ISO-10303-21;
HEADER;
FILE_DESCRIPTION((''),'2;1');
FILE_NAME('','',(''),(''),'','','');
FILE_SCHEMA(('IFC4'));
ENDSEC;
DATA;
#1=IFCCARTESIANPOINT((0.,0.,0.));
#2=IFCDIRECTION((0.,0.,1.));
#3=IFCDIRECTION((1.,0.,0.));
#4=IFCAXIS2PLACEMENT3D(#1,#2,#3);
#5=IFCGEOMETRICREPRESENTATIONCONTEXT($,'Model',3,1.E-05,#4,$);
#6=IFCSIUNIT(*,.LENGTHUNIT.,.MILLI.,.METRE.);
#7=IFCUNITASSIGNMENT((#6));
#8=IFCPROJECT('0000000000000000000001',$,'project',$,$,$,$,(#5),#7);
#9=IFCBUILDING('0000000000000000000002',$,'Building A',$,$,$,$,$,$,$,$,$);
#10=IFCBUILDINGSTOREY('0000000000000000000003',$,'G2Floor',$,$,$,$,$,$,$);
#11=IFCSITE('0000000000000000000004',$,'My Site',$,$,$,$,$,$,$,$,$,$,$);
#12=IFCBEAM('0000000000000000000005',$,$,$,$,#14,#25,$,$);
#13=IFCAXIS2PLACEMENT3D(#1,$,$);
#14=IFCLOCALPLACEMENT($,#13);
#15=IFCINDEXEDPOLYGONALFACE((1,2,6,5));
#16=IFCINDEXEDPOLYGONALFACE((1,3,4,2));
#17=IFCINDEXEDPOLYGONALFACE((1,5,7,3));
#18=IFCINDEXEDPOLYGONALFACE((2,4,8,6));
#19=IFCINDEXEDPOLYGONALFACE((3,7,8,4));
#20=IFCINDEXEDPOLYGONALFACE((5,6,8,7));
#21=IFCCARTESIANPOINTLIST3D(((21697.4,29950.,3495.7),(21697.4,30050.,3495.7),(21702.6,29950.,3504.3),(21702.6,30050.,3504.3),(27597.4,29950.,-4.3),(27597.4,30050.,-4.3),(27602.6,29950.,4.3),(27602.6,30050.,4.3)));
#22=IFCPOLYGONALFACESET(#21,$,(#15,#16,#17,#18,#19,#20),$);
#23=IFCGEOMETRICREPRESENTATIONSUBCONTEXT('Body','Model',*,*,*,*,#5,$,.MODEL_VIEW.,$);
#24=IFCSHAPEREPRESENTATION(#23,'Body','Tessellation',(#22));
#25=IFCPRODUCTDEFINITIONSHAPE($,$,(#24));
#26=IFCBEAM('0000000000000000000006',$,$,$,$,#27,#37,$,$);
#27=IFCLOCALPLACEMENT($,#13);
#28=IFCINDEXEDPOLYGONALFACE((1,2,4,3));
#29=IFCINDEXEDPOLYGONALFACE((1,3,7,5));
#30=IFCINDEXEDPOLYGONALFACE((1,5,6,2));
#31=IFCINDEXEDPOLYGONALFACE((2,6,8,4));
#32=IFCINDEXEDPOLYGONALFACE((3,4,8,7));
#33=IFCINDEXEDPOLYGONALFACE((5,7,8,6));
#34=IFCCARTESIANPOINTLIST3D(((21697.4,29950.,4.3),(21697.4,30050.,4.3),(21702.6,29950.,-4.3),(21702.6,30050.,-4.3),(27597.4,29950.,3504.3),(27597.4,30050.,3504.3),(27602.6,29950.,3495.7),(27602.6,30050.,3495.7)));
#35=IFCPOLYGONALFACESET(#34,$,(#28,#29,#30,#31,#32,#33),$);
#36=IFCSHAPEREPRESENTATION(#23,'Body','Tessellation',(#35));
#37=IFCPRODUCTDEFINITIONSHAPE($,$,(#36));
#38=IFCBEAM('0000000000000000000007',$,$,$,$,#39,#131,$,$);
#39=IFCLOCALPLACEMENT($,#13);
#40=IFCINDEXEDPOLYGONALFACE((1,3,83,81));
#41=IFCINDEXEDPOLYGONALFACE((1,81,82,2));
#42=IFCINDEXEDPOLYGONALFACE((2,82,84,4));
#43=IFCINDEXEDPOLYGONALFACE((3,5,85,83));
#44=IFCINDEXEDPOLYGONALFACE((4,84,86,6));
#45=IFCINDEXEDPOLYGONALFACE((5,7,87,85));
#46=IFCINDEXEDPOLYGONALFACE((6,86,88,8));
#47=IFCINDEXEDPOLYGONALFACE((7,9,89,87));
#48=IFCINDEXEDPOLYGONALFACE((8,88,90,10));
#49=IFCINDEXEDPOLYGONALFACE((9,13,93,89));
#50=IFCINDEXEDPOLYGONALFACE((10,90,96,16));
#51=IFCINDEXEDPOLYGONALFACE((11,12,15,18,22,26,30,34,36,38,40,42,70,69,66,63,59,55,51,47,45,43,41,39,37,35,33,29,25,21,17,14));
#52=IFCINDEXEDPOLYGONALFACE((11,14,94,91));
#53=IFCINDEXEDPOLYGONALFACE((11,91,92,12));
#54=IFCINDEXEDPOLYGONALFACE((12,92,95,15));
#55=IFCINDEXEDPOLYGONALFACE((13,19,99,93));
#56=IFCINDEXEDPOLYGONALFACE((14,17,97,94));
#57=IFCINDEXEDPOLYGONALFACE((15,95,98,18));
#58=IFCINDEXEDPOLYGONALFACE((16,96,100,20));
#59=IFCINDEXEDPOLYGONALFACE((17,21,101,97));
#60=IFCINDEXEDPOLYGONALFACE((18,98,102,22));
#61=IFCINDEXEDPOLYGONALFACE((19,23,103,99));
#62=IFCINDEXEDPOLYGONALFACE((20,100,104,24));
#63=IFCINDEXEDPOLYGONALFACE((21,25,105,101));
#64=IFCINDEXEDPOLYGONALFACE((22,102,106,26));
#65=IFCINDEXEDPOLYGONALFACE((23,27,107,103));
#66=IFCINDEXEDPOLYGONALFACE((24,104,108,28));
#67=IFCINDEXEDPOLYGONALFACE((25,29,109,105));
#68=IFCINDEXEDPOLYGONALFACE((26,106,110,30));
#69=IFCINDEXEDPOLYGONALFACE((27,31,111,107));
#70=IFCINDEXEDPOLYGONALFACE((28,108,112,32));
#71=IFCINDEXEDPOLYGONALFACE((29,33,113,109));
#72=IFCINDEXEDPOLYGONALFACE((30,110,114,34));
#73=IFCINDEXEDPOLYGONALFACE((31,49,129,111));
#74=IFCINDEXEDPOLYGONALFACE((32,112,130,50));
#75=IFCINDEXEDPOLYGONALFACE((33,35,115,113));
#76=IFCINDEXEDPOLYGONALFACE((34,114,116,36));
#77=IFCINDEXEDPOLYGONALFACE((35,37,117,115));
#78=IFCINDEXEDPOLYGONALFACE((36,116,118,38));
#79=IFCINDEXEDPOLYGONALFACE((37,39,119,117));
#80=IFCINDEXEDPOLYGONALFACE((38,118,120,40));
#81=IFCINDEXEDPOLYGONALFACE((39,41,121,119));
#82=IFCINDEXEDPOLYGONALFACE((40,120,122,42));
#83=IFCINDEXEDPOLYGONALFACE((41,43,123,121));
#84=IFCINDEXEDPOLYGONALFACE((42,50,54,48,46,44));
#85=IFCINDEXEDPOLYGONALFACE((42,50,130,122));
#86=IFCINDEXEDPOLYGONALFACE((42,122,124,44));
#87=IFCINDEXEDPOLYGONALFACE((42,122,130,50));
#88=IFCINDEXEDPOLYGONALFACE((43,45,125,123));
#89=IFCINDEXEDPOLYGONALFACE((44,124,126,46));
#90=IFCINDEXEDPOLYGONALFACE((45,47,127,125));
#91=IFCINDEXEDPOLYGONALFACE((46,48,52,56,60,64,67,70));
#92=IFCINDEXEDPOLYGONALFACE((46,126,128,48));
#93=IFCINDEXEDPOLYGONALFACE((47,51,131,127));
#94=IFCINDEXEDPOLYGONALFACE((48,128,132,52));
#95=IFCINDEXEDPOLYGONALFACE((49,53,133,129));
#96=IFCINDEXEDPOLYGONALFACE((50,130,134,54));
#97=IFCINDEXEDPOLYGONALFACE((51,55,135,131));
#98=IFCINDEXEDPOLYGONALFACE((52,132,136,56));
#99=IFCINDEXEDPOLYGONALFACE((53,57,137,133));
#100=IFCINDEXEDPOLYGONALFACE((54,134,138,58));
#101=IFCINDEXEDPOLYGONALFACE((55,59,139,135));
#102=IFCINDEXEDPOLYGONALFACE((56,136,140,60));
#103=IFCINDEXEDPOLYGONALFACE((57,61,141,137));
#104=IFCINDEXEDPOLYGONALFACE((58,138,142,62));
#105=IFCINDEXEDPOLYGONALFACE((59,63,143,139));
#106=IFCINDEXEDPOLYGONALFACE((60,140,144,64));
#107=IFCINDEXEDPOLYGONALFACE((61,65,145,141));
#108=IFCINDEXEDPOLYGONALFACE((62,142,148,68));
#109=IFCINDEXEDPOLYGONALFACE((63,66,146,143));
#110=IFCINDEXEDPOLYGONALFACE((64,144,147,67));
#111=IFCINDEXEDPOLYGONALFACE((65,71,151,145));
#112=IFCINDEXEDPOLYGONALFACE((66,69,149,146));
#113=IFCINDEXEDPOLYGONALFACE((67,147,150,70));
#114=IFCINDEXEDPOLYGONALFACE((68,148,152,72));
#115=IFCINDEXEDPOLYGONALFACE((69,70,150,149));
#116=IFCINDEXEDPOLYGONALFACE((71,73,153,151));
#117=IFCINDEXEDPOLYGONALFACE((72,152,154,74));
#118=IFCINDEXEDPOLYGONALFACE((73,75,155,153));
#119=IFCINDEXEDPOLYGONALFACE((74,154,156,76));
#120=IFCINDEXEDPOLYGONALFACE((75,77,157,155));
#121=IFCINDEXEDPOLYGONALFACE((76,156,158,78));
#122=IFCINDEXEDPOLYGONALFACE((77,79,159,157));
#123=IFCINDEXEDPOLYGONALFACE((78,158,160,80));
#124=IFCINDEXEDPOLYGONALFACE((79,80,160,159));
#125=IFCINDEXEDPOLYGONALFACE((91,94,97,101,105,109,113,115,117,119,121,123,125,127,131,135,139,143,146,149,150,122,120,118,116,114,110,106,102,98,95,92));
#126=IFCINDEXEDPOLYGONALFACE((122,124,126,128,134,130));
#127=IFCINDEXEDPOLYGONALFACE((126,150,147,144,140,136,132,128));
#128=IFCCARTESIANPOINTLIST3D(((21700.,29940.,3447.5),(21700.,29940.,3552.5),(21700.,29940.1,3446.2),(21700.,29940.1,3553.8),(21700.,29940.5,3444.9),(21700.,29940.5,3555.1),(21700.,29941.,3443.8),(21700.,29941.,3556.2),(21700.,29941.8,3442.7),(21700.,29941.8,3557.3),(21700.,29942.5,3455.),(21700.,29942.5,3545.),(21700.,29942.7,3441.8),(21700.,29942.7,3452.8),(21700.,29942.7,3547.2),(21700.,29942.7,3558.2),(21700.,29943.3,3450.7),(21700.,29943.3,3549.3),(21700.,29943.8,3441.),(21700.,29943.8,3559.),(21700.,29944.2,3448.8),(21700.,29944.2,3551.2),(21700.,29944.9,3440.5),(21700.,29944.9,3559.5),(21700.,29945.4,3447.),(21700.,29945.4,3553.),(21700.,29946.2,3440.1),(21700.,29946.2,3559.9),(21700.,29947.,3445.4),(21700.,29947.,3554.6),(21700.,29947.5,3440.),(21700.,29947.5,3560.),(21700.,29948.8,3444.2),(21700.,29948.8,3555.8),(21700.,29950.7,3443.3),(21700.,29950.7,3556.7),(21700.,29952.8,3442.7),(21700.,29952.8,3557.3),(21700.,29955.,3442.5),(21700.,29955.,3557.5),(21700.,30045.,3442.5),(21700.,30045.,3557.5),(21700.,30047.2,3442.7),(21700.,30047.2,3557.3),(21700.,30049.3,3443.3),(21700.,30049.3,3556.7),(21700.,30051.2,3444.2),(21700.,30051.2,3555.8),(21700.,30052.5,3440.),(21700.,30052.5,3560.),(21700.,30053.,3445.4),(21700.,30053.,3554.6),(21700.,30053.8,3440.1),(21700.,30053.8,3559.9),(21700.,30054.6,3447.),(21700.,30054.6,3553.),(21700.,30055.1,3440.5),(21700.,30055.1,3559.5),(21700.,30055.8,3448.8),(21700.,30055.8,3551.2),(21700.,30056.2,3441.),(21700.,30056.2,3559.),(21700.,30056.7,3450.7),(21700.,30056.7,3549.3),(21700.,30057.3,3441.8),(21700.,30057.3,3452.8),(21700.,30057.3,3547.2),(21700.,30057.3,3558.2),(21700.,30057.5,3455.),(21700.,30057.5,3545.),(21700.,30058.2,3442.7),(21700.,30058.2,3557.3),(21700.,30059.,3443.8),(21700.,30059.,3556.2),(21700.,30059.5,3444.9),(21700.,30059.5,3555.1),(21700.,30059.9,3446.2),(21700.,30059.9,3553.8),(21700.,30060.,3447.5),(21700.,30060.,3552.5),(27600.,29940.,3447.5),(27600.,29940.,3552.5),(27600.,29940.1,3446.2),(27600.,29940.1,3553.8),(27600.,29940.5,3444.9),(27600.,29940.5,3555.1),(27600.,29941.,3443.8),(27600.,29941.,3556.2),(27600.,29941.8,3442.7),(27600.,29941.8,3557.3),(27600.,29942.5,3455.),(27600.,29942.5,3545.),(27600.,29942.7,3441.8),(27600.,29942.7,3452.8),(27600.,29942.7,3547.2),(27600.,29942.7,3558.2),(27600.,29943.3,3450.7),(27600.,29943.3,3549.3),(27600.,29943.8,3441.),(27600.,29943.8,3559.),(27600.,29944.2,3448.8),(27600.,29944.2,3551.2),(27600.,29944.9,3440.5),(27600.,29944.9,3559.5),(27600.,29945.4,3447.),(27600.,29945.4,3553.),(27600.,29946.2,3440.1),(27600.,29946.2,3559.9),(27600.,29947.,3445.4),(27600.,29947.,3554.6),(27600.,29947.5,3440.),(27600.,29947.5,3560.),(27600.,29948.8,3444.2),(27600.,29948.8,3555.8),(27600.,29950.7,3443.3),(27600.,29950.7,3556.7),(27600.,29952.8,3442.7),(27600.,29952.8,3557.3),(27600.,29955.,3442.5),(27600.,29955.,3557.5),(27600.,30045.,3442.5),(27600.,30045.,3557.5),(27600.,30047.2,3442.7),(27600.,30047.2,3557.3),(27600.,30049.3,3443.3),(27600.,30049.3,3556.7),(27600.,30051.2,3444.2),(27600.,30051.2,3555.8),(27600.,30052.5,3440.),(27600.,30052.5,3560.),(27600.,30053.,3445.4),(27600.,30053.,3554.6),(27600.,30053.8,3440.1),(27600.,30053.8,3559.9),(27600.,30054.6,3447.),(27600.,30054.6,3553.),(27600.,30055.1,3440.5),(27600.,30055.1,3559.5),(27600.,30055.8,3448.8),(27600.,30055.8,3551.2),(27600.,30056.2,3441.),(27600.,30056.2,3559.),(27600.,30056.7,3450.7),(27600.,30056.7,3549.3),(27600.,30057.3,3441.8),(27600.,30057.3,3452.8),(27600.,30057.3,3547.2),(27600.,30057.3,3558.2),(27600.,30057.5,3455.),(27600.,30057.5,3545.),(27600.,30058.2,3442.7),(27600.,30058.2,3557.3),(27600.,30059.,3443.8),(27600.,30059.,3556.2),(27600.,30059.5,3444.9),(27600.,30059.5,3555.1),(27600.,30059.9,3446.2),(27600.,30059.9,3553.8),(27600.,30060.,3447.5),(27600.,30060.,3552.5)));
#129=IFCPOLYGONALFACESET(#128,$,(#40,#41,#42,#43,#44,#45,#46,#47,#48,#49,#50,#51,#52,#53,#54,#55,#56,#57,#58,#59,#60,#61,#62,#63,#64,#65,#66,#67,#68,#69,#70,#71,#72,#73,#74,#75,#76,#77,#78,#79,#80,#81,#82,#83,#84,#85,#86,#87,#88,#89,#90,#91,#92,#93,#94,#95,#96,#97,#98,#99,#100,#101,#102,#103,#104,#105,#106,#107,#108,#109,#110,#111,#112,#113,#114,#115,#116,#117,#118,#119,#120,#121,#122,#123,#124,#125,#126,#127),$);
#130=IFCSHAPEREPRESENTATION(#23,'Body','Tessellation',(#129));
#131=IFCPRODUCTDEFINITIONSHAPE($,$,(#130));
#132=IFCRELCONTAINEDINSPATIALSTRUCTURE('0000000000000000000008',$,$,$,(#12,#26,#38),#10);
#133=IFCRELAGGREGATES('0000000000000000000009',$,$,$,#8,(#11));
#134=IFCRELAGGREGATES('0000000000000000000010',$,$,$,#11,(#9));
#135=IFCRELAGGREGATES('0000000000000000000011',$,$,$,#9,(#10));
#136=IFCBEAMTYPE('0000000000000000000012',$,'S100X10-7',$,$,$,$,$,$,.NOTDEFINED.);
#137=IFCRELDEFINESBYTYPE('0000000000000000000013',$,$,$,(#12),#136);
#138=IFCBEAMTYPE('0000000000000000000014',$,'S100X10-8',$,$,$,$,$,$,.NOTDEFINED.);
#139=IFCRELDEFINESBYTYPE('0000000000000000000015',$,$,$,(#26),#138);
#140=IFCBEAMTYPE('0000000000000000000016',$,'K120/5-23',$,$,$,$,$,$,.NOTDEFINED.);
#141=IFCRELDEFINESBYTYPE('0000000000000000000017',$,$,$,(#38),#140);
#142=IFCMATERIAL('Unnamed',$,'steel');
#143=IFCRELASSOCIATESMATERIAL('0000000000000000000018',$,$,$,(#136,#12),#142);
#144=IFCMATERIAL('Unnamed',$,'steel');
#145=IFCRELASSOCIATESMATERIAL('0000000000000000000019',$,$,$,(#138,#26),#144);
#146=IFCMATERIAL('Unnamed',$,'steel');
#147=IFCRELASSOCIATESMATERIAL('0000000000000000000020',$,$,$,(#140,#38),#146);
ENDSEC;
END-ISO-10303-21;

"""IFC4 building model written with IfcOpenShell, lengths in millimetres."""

from ifc_helpers import new_model, si_unit, frame, origin_with_axes, place, context, subcontext, project, spatial, polyline, outline, extrude, material, material_profile, profile_set, profile_usage, type_object, element, save


model = new_model("IFC4")

# Units and contexts
model_context = context("Model", 3, precision=1e-05, world=origin_with_axes())
body_context = subcontext(model_context, "Body", "Model", "MODEL_VIEW")
ifc_project = project(units=[si_unit("LENGTHUNIT", "METRE", prefix="MILLI")], contexts=[model_context])

# Site, building, storey
site = spatial("IfcSite", under=ifc_project, Name="My Site")
building = spatial("IfcBuilding", under=site, Name="Building A")
storey = spatial("IfcBuildingStorey", under=building, Name="G2Floor")

# Beams
ifc_material_1 = material(Name="Unnamed", Category="steel")
ifc_material_profile_1 = material_profile(ifc_material_1, outline(polyline([(50.0, -5.0), (50.0, 5.0), (50.0, 5.0), (-50.0, 5.0), (-50.0, 5.0), (-50.0, -5.0), (-50.0, -5.0), (50.0, -5.0)])))
ifc_profile_set_1 = profile_set([ifc_material_profile_1], Name="S100X10-7")
ifc_profile_usage_1 = profile_usage(ifc_profile_set_1)
beam_type_1 = type_object("IfcBeamType", Name="S100X10-7", PredefinedType="NOTDEFINED", material=ifc_profile_set_1)
beam_1_placement = place(None, frame((21700.0, 30000.0, 3500.0), z_axis=(0.860055, 0.0, -0.510202), x_axis=(0.0, -1.0, 0.0)))
element("IfcBeam", 1, at=beam_1_placement, inside=storey, type_object=beam_type_1, material=ifc_profile_usage_1, context=body_context, shape_type="SweptSolid", body=[
    extrude(outline(polyline([(50.0, -5.0), (50.0, 5.0), (50.0, 5.0), (-50.0, 5.0), (-50.0, 5.0), (-50.0, -5.0), (-50.0, -5.0), (50.0, -5.0)])), origin_with_axes(), (0.0, 0.0, 1.0), 6860.0),
])
ifc_material_2 = material(Name="Unnamed", Category="steel")
ifc_material_profile_2 = material_profile(ifc_material_2, outline(polyline([(50.0, -5.0), (50.0, 5.0), (50.0, 5.0), (-50.0, 5.0), (-50.0, 5.0), (-50.0, -5.0), (-50.0, -5.0), (50.0, -5.0)])))
ifc_profile_set_2 = profile_set([ifc_material_profile_2], Name="S100X10-8")
ifc_profile_usage_2 = profile_usage(ifc_profile_set_2)
beam_type_2 = type_object("IfcBeamType", Name="S100X10-8", PredefinedType="NOTDEFINED", material=ifc_profile_set_2)
beam_2_placement = place(None, frame((21700.0, 30000.0, 0.0), z_axis=(0.860055, 0.0, 0.510202), x_axis=(0.0, -1.0, 0.0)))
element("IfcBeam", 2, at=beam_2_placement, inside=storey, type_object=beam_type_2, material=ifc_profile_usage_2, context=body_context, shape_type="SweptSolid", body=[
    extrude(outline(polyline([(50.0, -5.0), (50.0, 5.0), (50.0, 5.0), (-50.0, 5.0), (-50.0, 5.0), (-50.0, -5.0), (-50.0, -5.0), (50.0, -5.0)])), origin_with_axes(), (0.0, 0.0, 1.0), 6860.0),
])
ifc_material_3 = material(Name="Unnamed", Category="steel")
ifc_material_profile_3 = material_profile(ifc_material_3, outline(polyline([(-52.5, -60.0), (52.5, -60.0), (52.5, -60.0), (53.8, -59.9), (53.8, -59.9), (55.1, -59.5), (55.1, -59.5), (56.2, -59.0), (56.2, -59.0), (57.3, -58.2), (57.3, -58.2), (58.2, -57.3), (58.2, -57.3), (59.0, -56.2), (59.0, -56.2), (59.5, -55.1), (59.5, -55.1), (59.9, -53.8), (59.9, -53.8), (60.0, -52.5), (60.0, -52.5), (60.0, 52.5), (60.0, 52.5), (59.9, 53.8), (59.9, 53.8), (59.5, 55.1), (59.5, 55.1), (59.0, 56.2), (59.0, 56.2), (58.2, 57.3), (58.2, 57.3), (57.3, 58.2), (57.3, 58.2), (56.2, 59.0), (56.2, 59.0), (55.1, 59.5), (55.1, 59.5), (53.8, 59.9), (53.8, 59.9), (52.5, 60.0), (52.5, 60.0), (-52.5, 60.0), (-52.5, 60.0), (-53.8, 59.9), (-53.8, 59.9), (-55.1, 59.5), (-55.1, 59.5), (-56.2, 59.0), (-56.2, 59.0), (-57.3, 58.2), (-57.3, 58.2), (-58.2, 57.3), (-58.2, 57.3), (-59.0, 56.2), (-59.0, 56.2), (-59.5, 55.1), (-59.5, 55.1), (-59.9, 53.8), (-59.9, 53.8), (-60.0, 52.5), (-60.0, 52.5), (-60.0, -52.5), (-60.0, -52.5), (-59.9, -53.8), (-59.9, -53.8), (-59.5, -55.1), (-59.5, -55.1), (-59.0, -56.2), (-59.0, -56.2), (-58.2, -57.3), (-58.2, -57.3), (-57.3, -58.2), (-57.3, -58.2), (-56.2, -59.0), (-56.2, -59.0), (-55.1, -59.5), (-55.1, -59.5), (-53.8, -59.9), (-53.8, -59.9), (-52.5, -60.0), (-52.5, -60.0), (-45.0, -57.5), (-45.0, -57.5), (45.0, -57.5), (45.0, -57.5), (47.2, -57.3), (47.2, -57.3), (49.3, -56.7), (49.3, -56.7), (51.2, -55.8), (51.2, -55.8), (53.0, -54.6), (53.0, -54.6), (54.6, -53.0), (54.6, -53.0), (55.8, -51.2), (55.8, -51.2), (56.7, -49.3), (56.7, -49.3), (57.3, -47.2), (57.3, -47.2), (57.5, -45.0), (57.5, -45.0), (57.5, 45.0), (57.5, 45.0), (57.3, 47.2), (57.3, 47.2), (56.7, 49.3), (56.7, 49.3), (55.8, 51.2), (55.8, 51.2), (54.6, 53.0), (54.6, 53.0), (53.0, 54.6), (53.0, 54.6), (51.2, 55.8), (51.2, 55.8), (49.3, 56.7), (49.3, 56.7), (47.2, 57.3), (47.2, 57.3), (45.0, 57.5), (45.0, 57.5), (-45.0, 57.5), (-45.0, 57.5), (-47.2, 57.3), (-47.2, 57.3), (-49.3, 56.7), (-49.3, 56.7), (-51.2, 55.8), (-51.2, 55.8), (-53.0, 54.6), (-53.0, 54.6), (-54.6, 53.0), (-54.6, 53.0), (-55.8, 51.2), (-55.8, 51.2), (-56.7, 49.3), (-56.7, 49.3), (-57.3, 47.2), (-57.3, 47.2), (-57.5, 45.0), (-57.5, 45.0), (-57.5, -45.0), (-57.5, -45.0), (-57.3, -47.2), (-57.3, -47.2), (-56.7, -49.3), (-56.7, -49.3), (-55.8, -51.2), (-55.8, -51.2), (-54.6, -53.0), (-54.6, -53.0), (-53.0, -54.6), (-53.0, -54.6), (-51.2, -55.8), (-51.2, -55.8), (-49.3, -56.7), (-49.3, -56.7), (-47.2, -57.3), (-47.2, -57.3), (-45.0, -57.5), (-45.0, -57.5), (-52.5, -60.0)])))
ifc_profile_set_3 = profile_set([ifc_material_profile_3], Name="K120/5-23")
ifc_profile_usage_3 = profile_usage(ifc_profile_set_3)
beam_type_3 = type_object("IfcBeamType", Name="K120/5-23", PredefinedType="NOTDEFINED", material=ifc_profile_set_3)
beam_3_placement = place(None, frame((21700.0, 30000.0, 3500.0), z_axis=(1.0, 0.0, 0.0), x_axis=(0.0, -1.0, 0.0)))
element("IfcBeam", 3, at=beam_3_placement, inside=storey, type_object=beam_type_3, material=ifc_profile_usage_3, context=body_context, shape_type="SweptSolid", body=[
    extrude(outline(polyline([(-52.5, -60.0), (52.5, -60.0), (52.5, -60.0), (53.8, -59.9), (53.8, -59.9), (55.1, -59.5), (55.1, -59.5), (56.2, -59.0), (56.2, -59.0), (57.3, -58.2), (57.3, -58.2), (58.2, -57.3), (58.2, -57.3), (59.0, -56.2), (59.0, -56.2), (59.5, -55.1), (59.5, -55.1), (59.9, -53.8), (59.9, -53.8), (60.0, -52.5), (60.0, -52.5), (60.0, 52.5), (60.0, 52.5), (59.9, 53.8), (59.9, 53.8), (59.5, 55.1), (59.5, 55.1), (59.0, 56.2), (59.0, 56.2), (58.2, 57.3), (58.2, 57.3), (57.3, 58.2), (57.3, 58.2), (56.2, 59.0), (56.2, 59.0), (55.1, 59.5), (55.1, 59.5), (53.8, 59.9), (53.8, 59.9), (52.5, 60.0), (52.5, 60.0), (-52.5, 60.0), (-52.5, 60.0), (-53.8, 59.9), (-53.8, 59.9), (-55.1, 59.5), (-55.1, 59.5), (-56.2, 59.0), (-56.2, 59.0), (-57.3, 58.2), (-57.3, 58.2), (-58.2, 57.3), (-58.2, 57.3), (-59.0, 56.2), (-59.0, 56.2), (-59.5, 55.1), (-59.5, 55.1), (-59.9, 53.8), (-59.9, 53.8), (-60.0, 52.5), (-60.0, 52.5), (-60.0, -52.5), (-60.0, -52.5), (-59.9, -53.8), (-59.9, -53.8), (-59.5, -55.1), (-59.5, -55.1), (-59.0, -56.2), (-59.0, -56.2), (-58.2, -57.3), (-58.2, -57.3), (-57.3, -58.2), (-57.3, -58.2), (-56.2, -59.0), (-56.2, -59.0), (-55.1, -59.5), (-55.1, -59.5), (-53.8, -59.9), (-53.8, -59.9), (-52.5, -60.0), (-52.5, -60.0), (-45.0, -57.5), (-45.0, -57.5), (45.0, -57.5), (45.0, -57.5), (47.2, -57.3), (47.2, -57.3), (49.3, -56.7), (49.3, -56.7), (51.2, -55.8), (51.2, -55.8), (53.0, -54.6), (53.0, -54.6), (54.6, -53.0), (54.6, -53.0), (55.8, -51.2), (55.8, -51.2), (56.7, -49.3), (56.7, -49.3), (57.3, -47.2), (57.3, -47.2), (57.5, -45.0), (57.5, -45.0), (57.5, 45.0), (57.5, 45.0), (57.3, 47.2), (57.3, 47.2), (56.7, 49.3), (56.7, 49.3), (55.8, 51.2), (55.8, 51.2), (54.6, 53.0), (54.6, 53.0), (53.0, 54.6), (53.0, 54.6), (51.2, 55.8), (51.2, 55.8), (49.3, 56.7), (49.3, 56.7), (47.2, 57.3), (47.2, 57.3), (45.0, 57.5), (45.0, 57.5), (-45.0, 57.5), (-45.0, 57.5), (-47.2, 57.3), (-47.2, 57.3), (-49.3, 56.7), (-49.3, 56.7), (-51.2, 55.8), (-51.2, 55.8), (-53.0, 54.6), (-53.0, 54.6), (-54.6, 53.0), (-54.6, 53.0), (-55.8, 51.2), (-55.8, 51.2), (-56.7, 49.3), (-56.7, 49.3), (-57.3, 47.2), (-57.3, 47.2), (-57.5, 45.0), (-57.5, 45.0), (-57.5, -45.0), (-57.5, -45.0), (-57.3, -47.2), (-57.3, -47.2), (-56.7, -49.3), (-56.7, -49.3), (-55.8, -51.2), (-55.8, -51.2), (-54.6, -53.0), (-54.6, -53.0), (-53.0, -54.6), (-53.0, -54.6), (-51.2, -55.8), (-51.2, -55.8), (-49.3, -56.7), (-49.3, -56.7), (-47.2, -57.3), (-47.2, -57.3), (-45.0, -57.5), (-45.0, -57.5), (-52.5, -60.0)])), origin_with_axes(), (0.0, 0.0, 1.0), 5900.0),
])

save(model, "model.ifc")
